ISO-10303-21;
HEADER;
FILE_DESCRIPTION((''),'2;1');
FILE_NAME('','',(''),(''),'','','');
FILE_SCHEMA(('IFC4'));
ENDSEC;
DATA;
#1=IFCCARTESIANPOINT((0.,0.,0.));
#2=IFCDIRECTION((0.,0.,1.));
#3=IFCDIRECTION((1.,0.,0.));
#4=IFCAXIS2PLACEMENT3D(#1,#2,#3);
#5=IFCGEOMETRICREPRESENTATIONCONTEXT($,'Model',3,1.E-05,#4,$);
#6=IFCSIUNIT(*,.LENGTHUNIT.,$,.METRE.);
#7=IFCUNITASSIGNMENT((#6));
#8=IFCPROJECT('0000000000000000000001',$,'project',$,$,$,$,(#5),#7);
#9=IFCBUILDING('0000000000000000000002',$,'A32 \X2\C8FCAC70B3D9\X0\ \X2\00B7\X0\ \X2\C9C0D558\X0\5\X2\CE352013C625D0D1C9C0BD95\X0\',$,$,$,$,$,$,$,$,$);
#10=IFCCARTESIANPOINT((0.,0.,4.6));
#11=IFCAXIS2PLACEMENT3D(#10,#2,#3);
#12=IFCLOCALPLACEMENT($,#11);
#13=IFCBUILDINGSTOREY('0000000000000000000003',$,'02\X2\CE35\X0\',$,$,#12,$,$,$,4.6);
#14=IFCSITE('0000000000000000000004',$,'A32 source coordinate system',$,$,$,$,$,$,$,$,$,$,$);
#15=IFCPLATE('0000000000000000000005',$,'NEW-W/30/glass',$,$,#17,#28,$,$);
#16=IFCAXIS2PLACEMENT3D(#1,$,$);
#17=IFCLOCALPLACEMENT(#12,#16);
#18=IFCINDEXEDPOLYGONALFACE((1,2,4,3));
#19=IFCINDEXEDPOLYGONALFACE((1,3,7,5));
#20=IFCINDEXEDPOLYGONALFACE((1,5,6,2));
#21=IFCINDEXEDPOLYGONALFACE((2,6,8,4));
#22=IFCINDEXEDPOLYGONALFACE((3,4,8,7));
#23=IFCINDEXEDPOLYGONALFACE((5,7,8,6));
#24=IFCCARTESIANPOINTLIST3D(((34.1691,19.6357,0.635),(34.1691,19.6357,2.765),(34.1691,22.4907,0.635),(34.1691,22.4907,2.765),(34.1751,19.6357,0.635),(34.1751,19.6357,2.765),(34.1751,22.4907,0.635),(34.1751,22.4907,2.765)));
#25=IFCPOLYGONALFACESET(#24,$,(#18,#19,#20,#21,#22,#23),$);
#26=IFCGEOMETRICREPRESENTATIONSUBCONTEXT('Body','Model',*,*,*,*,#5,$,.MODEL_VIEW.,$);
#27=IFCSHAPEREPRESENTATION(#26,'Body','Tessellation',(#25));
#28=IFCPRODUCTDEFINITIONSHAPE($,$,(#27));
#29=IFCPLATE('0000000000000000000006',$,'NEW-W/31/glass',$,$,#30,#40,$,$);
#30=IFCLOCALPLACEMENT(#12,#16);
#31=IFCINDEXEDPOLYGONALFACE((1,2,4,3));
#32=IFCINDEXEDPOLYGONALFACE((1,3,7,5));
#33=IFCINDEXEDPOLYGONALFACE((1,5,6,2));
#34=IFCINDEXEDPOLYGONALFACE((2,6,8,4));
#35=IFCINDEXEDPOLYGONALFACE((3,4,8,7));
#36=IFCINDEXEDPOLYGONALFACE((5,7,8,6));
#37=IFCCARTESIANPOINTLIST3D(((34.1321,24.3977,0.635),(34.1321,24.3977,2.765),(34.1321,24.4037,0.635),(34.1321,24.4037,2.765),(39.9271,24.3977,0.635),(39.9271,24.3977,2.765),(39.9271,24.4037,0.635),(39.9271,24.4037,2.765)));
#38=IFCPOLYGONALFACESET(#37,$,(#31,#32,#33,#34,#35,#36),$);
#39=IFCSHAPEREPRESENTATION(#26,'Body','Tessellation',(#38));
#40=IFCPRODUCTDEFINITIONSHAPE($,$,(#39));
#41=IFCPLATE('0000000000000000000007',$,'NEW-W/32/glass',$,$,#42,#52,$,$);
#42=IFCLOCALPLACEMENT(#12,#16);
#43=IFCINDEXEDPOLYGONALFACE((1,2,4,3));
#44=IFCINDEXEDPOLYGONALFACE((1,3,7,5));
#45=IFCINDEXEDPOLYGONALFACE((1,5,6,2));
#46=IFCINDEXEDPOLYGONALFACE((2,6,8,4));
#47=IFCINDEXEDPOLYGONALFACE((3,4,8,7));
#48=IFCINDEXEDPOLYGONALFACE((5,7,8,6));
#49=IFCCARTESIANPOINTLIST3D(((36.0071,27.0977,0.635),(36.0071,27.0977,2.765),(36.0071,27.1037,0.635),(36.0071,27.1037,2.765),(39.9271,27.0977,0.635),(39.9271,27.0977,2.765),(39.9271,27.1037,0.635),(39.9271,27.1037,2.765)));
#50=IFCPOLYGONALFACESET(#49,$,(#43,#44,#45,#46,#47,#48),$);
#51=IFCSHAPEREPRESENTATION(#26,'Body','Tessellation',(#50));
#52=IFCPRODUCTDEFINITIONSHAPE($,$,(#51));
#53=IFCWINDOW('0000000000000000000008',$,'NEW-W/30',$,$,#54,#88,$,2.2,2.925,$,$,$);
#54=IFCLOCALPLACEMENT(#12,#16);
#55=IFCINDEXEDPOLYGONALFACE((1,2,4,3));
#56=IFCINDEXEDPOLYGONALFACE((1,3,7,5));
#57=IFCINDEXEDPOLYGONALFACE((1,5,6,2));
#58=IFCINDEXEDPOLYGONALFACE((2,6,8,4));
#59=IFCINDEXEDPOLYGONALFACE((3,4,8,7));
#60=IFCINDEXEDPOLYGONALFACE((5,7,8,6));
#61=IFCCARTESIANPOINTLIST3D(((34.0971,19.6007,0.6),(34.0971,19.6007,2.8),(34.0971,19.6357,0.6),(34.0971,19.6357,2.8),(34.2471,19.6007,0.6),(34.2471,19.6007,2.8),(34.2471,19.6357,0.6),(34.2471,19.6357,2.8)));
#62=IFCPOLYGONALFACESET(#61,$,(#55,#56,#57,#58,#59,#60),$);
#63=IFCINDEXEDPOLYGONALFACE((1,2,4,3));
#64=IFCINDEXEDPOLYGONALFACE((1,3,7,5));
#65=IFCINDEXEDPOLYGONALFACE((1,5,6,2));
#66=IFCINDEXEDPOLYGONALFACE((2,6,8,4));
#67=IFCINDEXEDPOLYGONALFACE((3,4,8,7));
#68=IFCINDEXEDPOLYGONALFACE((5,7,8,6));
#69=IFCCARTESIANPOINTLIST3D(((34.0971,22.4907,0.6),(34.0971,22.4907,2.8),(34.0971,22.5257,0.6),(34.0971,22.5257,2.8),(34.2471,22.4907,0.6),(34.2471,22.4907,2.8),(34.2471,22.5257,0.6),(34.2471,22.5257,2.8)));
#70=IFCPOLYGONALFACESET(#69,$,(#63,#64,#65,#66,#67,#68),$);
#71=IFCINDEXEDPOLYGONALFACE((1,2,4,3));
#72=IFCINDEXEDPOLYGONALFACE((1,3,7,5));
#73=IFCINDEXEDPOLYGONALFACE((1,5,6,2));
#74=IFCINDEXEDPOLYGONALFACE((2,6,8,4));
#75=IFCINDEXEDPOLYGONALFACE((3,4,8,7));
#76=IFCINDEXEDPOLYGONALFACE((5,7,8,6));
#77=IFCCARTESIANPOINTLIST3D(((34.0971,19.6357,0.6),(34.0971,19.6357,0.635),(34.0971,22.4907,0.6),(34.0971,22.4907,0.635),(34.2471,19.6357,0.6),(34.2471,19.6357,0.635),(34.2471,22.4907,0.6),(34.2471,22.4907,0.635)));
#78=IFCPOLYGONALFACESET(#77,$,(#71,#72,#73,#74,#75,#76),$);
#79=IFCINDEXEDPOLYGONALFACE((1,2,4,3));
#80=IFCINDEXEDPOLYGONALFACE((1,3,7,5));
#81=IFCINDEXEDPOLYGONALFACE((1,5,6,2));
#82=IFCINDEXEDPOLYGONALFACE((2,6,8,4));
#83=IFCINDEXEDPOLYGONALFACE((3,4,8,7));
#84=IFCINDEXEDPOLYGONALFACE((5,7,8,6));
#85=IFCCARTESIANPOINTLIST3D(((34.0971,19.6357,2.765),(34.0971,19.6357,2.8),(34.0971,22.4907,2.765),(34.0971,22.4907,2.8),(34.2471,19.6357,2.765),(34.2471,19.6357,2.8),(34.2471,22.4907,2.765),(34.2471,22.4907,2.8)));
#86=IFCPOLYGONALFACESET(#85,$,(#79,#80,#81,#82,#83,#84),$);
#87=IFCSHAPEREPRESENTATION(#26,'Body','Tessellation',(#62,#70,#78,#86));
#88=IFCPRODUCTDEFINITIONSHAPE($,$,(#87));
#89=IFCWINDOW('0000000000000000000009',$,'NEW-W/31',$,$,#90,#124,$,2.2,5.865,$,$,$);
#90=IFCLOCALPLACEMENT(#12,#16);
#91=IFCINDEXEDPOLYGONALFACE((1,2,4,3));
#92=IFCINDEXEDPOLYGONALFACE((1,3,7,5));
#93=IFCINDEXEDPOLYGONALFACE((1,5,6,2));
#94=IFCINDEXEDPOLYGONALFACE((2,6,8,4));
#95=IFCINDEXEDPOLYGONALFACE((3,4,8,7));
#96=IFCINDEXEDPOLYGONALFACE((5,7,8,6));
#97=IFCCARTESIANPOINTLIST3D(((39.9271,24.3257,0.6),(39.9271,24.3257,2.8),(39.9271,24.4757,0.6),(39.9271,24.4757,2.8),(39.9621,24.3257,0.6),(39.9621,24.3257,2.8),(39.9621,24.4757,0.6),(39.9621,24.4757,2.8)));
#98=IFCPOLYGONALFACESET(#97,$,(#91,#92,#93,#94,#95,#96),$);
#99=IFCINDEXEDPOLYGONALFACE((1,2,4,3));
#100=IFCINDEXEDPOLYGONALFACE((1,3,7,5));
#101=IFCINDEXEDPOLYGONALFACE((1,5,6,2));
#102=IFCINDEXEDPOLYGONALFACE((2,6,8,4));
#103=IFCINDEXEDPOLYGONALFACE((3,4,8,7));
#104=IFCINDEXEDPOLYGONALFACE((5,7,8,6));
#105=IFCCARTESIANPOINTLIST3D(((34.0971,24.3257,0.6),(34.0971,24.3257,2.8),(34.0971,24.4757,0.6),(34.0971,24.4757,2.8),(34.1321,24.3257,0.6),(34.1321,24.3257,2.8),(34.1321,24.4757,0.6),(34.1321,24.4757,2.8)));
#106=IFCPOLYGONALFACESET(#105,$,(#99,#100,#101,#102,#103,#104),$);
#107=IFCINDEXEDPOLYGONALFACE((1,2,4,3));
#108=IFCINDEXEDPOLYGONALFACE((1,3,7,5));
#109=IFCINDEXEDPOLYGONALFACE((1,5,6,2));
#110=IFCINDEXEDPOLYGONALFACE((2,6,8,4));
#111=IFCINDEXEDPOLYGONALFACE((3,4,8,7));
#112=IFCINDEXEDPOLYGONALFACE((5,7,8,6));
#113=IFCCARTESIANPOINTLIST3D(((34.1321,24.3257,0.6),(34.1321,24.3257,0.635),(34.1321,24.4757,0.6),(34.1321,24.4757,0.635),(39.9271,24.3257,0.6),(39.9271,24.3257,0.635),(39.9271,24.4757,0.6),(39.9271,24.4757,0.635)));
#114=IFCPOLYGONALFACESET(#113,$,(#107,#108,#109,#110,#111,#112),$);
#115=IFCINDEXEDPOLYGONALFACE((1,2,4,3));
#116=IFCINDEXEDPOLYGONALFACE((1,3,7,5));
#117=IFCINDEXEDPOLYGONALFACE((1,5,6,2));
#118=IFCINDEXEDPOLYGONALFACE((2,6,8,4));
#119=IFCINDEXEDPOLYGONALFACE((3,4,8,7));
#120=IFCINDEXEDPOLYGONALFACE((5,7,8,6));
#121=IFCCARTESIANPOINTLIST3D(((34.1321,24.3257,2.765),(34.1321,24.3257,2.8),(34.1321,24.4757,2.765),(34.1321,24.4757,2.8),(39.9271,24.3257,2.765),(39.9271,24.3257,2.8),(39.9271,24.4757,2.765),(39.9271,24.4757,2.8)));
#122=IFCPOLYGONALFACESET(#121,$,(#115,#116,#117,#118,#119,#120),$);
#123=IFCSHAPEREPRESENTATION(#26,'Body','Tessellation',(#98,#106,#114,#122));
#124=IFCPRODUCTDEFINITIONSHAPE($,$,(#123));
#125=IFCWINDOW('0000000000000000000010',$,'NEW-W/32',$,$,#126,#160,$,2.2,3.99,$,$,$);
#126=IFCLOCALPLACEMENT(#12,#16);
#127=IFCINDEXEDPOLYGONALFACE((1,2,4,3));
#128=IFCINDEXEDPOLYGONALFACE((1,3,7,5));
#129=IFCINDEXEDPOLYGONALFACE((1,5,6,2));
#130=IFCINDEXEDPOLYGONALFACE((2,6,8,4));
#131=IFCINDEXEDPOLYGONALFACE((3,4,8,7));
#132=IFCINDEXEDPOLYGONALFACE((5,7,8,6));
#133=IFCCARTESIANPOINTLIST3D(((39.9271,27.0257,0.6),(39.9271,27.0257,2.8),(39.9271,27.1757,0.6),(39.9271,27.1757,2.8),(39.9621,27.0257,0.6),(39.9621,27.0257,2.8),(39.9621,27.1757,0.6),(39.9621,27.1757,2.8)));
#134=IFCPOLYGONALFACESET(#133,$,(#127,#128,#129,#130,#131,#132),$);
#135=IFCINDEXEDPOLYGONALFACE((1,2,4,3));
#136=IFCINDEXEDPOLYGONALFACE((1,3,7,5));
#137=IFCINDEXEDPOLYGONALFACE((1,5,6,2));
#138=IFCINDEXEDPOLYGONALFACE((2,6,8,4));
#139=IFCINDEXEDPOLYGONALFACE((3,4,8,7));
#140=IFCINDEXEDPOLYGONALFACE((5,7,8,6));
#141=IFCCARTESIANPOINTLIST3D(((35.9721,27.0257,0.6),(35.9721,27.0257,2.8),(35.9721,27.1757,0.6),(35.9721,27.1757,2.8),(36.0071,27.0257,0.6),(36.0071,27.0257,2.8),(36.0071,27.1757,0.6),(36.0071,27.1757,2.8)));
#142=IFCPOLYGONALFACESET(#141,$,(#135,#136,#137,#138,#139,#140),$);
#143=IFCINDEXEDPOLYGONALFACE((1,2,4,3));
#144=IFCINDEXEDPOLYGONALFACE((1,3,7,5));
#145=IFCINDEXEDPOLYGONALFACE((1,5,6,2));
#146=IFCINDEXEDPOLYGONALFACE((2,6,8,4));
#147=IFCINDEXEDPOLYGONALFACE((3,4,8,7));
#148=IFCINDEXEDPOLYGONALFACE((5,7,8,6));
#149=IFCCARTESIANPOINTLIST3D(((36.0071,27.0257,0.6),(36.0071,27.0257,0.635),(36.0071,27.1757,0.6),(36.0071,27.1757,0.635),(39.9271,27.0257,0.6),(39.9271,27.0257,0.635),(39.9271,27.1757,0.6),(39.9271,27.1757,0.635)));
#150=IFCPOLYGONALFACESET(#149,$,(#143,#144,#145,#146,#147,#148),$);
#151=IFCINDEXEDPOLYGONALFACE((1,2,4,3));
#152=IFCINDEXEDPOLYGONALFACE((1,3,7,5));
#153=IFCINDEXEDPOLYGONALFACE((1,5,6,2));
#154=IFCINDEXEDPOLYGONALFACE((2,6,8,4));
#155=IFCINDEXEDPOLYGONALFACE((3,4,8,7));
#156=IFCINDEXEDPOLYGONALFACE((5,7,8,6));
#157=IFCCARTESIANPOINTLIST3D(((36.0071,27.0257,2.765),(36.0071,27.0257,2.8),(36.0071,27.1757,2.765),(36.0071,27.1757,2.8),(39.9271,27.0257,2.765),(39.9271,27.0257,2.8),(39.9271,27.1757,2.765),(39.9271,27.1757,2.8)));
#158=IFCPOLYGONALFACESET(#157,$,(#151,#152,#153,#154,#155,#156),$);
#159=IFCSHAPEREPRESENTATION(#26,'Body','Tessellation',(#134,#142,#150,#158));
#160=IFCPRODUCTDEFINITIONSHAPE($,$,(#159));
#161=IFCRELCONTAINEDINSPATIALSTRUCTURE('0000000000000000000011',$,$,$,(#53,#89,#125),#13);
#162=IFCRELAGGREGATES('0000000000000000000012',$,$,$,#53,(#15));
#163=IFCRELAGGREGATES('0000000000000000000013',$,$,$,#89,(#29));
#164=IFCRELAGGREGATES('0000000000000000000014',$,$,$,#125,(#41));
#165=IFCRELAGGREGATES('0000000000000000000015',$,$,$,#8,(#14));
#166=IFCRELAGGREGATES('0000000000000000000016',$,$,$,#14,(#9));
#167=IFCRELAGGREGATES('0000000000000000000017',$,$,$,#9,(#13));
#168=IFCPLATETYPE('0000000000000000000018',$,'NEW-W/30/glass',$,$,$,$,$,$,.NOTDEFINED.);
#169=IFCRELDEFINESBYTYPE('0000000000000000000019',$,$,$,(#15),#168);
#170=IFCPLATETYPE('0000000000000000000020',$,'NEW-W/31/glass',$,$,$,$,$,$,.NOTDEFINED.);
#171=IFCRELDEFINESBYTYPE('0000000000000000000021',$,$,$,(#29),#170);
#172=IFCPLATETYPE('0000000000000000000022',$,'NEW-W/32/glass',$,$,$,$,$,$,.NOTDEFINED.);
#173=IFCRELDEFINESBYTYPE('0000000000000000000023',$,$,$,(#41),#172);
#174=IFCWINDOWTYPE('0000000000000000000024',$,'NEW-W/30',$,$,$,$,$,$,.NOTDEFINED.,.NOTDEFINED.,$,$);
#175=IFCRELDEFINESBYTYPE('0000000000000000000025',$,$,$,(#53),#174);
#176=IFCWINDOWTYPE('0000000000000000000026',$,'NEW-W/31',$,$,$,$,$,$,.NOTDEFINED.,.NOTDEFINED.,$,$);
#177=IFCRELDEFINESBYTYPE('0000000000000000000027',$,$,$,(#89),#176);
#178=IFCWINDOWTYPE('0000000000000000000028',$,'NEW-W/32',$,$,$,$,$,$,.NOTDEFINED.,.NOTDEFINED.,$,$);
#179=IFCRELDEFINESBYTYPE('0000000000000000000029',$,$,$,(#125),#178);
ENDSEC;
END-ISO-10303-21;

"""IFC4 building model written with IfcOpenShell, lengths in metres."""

from ifc_helpers import new_model, si_unit, frame, origin, origin_with_axes, place, context, subcontext, project, spatial, polyline, outline, extrude, source, transform, mapped, type_object, type_shapes, element, aggregate, save


model = new_model("IFC4")

# Units and contexts
model_context = context("Model", 3, precision=1e-05, world=origin_with_axes())
body_context = subcontext(model_context, "Body", "Model", "MODEL_VIEW")
ifc_project = project(units=[si_unit("LENGTHUNIT", "METRE")], contexts=[model_context])

# Plates
storey_placement = place(None, frame((0.0, 0.0, 4.6), z_axis=(0.0, 0.0, 1.0), x_axis=(1.0, 0.0, 0.0)))
plate_type_1 = type_object("IfcPlateType", Name="NEW-W/30/glass", PredefinedType="NOTDEFINED")
shared_shape_1 = source(origin(), body_context, "Body", "SweptSolid", [
    extrude(outline(polyline([(34.1751, 19.6357), (34.1691, 19.6357), (34.1691, 22.4907), (34.1751, 22.4907), (34.1751, 19.6357)])), frame((0.0, 0.0, 0.635)), (0.0, 0.0, 1.0), 2.13),
])
type_shapes(plate_type_1, [shared_shape_1])
window_1_placement = place(storey_placement, origin_with_axes())
plate_1_placement = place(window_1_placement, origin_with_axes())
plate_1 = element("IfcPlate", 1, at=plate_1_placement, type_object=plate_type_1, Name="NEW-W/30/glass", context=body_context, shape_type="MappedRepresentation", body=[
    mapped(shared_shape_1, transform((0.0, 0.0, 0.0), scale=1.0)),
])
plate_type_2 = type_object("IfcPlateType", Name="NEW-W/31/glass", PredefinedType="NOTDEFINED")
shared_shape_2 = source(origin(), body_context, "Body", "SweptSolid", [
    extrude(outline(polyline([(39.9271, 24.3977), (34.1321, 24.3977), (34.1321, 24.4037), (39.9271, 24.4037), (39.9271, 24.3977)])), frame((0.0, 0.0, 0.635)), (0.0, 0.0, 1.0), 2.13),
])
type_shapes(plate_type_2, [shared_shape_2])
window_2_placement = place(storey_placement, origin_with_axes())
plate_2_placement = place(window_2_placement, origin_with_axes())
plate_2 = element("IfcPlate", 2, at=plate_2_placement, type_object=plate_type_2, Name="NEW-W/31/glass", context=body_context, shape_type="MappedRepresentation", body=[
    mapped(shared_shape_2, transform((0.0, 0.0, 0.0), scale=1.0)),
])
plate_type_3 = type_object("IfcPlateType", Name="NEW-W/32/glass", PredefinedType="NOTDEFINED")
shared_shape_3 = source(origin(), body_context, "Body", "SweptSolid", [
    extrude(outline(polyline([(39.9271, 27.0977), (36.0071, 27.0977), (36.0071, 27.1037), (39.9271, 27.1037), (39.9271, 27.0977)])), frame((0.0, 0.0, 0.635)), (0.0, 0.0, 1.0), 2.13),
])
type_shapes(plate_type_3, [shared_shape_3])
window_3_placement = place(storey_placement, origin_with_axes())
plate_3_placement = place(window_3_placement, origin_with_axes())
plate_3 = element("IfcPlate", 3, at=plate_3_placement, type_object=plate_type_3, Name="NEW-W/32/glass", context=body_context, shape_type="MappedRepresentation", body=[
    mapped(shared_shape_3, transform((0.0, 0.0, 0.0), scale=1.0)),
])

# Site, building, storey
site = spatial("IfcSite", under=ifc_project, Name="A32 source coordinate system")
building = spatial("IfcBuilding", under=site, Name="A32 주거동 · 지하5층–옥탑지붕")
storey = spatial("IfcBuildingStorey", under=building, at=storey_placement, Name="02층", Elevation=4.6)

# Windows
window_type_1 = type_object("IfcWindowType", Name="NEW-W/30", PartitioningType="NOTDEFINED", PredefinedType="NOTDEFINED")
shared_shape_4 = source(origin(), body_context, "Body", "SweptSolid", [
    extrude(outline(polyline([(34.0971, 19.6007), (34.0971, 19.6357), (34.2471, 19.6357), (34.2471, 19.6007), (34.0971, 19.6007)])), frame((0.0, 0.0, 0.6)), (0.0, 0.0, 1.0), 2.2),
    extrude(outline(polyline([(34.0971, 22.4907), (34.0971, 22.5257), (34.2471, 22.5257), (34.2471, 22.4907), (34.0971, 22.4907)])), frame((0.0, 0.0, 0.6)), (0.0, 0.0, 1.0), 2.2),
    extrude(outline(polyline([(34.2471, 19.6357), (34.2471, 22.4907), (34.0971, 22.4907), (34.0971, 19.6357), (34.2471, 19.6357)])), frame((0.0, 0.0, 0.6)), (0.0, 0.0, 1.0), 0.035),
    extrude(outline(polyline([(34.2471, 19.6357), (34.2471, 22.4907), (34.0971, 22.4907), (34.0971, 19.6357), (34.2471, 19.6357)])), frame((0.0, 0.0, 2.765)), (0.0, 0.0, 1.0), 0.035),
])
type_shapes(window_type_1, [shared_shape_4])
window_1 = element("IfcWindow", 4, at=window_1_placement, inside=storey, type_object=window_type_1, Name="NEW-W/30", OverallHeight=2.2, OverallWidth=2.925, context=body_context, shape_type="MappedRepresentation", body=[
    mapped(shared_shape_4, transform((0.0, 0.0, 0.0), scale=1.0)),
])
aggregate(window_1, [plate_1])
window_type_2 = type_object("IfcWindowType", Name="NEW-W/31", PartitioningType="NOTDEFINED", PredefinedType="NOTDEFINED")
shared_shape_5 = source(origin(), body_context, "Body", "SweptSolid", [
    extrude(outline(polyline([(39.9271, 24.3257), (39.9271, 24.4757), (39.9621, 24.4757), (39.9621, 24.3257), (39.9271, 24.3257)])), frame((0.0, 0.0, 0.6)), (0.0, 0.0, 1.0), 2.2),
    extrude(outline(polyline([(34.0971, 24.3257), (34.0971, 24.4757), (34.1321, 24.4757), (34.1321, 24.3257), (34.0971, 24.3257)])), frame((0.0, 0.0, 0.6)), (0.0, 0.0, 1.0), 2.2),
    extrude(outline(polyline([(39.9271, 24.3257), (39.9271, 24.4757), (34.1321, 24.4757), (34.1321, 24.3257), (39.9271, 24.3257)])), frame((0.0, 0.0, 0.6)), (0.0, 0.0, 1.0), 0.035),
    extrude(outline(polyline([(39.9271, 24.3257), (39.9271, 24.4757), (34.1321, 24.4757), (34.1321, 24.3257), (39.9271, 24.3257)])), frame((0.0, 0.0, 2.765)), (0.0, 0.0, 1.0), 0.035),
])
type_shapes(window_type_2, [shared_shape_5])
window_2 = element("IfcWindow", 5, at=window_2_placement, inside=storey, type_object=window_type_2, Name="NEW-W/31", OverallHeight=2.2, OverallWidth=5.865, context=body_context, shape_type="MappedRepresentation", body=[
    mapped(shared_shape_5, transform((0.0, 0.0, 0.0), scale=1.0)),
])
aggregate(window_2, [plate_2])
window_type_3 = type_object("IfcWindowType", Name="NEW-W/32", PartitioningType="NOTDEFINED", PredefinedType="NOTDEFINED")
shared_shape_6 = source(origin(), body_context, "Body", "SweptSolid", [
    extrude(outline(polyline([(39.9271, 27.0257), (39.9271, 27.1757), (39.9621, 27.1757), (39.9621, 27.0257), (39.9271, 27.0257)])), frame((0.0, 0.0, 0.6)), (0.0, 0.0, 1.0), 2.2),
    extrude(outline(polyline([(35.9721, 27.0257), (35.9721, 27.1757), (36.0071, 27.1757), (36.0071, 27.0257), (35.9721, 27.0257)])), frame((0.0, 0.0, 0.6)), (0.0, 0.0, 1.0), 2.2),
    extrude(outline(polyline([(39.9271, 27.0257), (39.9271, 27.1757), (36.0071, 27.1757), (36.0071, 27.0257), (39.9271, 27.0257)])), frame((0.0, 0.0, 0.6)), (0.0, 0.0, 1.0), 0.035),
    extrude(outline(polyline([(39.9271, 27.0257), (39.9271, 27.1757), (36.0071, 27.1757), (36.0071, 27.0257), (39.9271, 27.0257)])), frame((0.0, 0.0, 2.765)), (0.0, 0.0, 1.0), 0.035),
])
type_shapes(window_type_3, [shared_shape_6])
window_3 = element("IfcWindow", 6, at=window_3_placement, inside=storey, type_object=window_type_3, Name="NEW-W/32", OverallHeight=2.2, OverallWidth=3.99, context=body_context, shape_type="MappedRepresentation", body=[
    mapped(shared_shape_6, transform((0.0, 0.0, 0.0), scale=1.0)),
])
aggregate(window_3, [plate_3])

save(model, "model.ifc")
